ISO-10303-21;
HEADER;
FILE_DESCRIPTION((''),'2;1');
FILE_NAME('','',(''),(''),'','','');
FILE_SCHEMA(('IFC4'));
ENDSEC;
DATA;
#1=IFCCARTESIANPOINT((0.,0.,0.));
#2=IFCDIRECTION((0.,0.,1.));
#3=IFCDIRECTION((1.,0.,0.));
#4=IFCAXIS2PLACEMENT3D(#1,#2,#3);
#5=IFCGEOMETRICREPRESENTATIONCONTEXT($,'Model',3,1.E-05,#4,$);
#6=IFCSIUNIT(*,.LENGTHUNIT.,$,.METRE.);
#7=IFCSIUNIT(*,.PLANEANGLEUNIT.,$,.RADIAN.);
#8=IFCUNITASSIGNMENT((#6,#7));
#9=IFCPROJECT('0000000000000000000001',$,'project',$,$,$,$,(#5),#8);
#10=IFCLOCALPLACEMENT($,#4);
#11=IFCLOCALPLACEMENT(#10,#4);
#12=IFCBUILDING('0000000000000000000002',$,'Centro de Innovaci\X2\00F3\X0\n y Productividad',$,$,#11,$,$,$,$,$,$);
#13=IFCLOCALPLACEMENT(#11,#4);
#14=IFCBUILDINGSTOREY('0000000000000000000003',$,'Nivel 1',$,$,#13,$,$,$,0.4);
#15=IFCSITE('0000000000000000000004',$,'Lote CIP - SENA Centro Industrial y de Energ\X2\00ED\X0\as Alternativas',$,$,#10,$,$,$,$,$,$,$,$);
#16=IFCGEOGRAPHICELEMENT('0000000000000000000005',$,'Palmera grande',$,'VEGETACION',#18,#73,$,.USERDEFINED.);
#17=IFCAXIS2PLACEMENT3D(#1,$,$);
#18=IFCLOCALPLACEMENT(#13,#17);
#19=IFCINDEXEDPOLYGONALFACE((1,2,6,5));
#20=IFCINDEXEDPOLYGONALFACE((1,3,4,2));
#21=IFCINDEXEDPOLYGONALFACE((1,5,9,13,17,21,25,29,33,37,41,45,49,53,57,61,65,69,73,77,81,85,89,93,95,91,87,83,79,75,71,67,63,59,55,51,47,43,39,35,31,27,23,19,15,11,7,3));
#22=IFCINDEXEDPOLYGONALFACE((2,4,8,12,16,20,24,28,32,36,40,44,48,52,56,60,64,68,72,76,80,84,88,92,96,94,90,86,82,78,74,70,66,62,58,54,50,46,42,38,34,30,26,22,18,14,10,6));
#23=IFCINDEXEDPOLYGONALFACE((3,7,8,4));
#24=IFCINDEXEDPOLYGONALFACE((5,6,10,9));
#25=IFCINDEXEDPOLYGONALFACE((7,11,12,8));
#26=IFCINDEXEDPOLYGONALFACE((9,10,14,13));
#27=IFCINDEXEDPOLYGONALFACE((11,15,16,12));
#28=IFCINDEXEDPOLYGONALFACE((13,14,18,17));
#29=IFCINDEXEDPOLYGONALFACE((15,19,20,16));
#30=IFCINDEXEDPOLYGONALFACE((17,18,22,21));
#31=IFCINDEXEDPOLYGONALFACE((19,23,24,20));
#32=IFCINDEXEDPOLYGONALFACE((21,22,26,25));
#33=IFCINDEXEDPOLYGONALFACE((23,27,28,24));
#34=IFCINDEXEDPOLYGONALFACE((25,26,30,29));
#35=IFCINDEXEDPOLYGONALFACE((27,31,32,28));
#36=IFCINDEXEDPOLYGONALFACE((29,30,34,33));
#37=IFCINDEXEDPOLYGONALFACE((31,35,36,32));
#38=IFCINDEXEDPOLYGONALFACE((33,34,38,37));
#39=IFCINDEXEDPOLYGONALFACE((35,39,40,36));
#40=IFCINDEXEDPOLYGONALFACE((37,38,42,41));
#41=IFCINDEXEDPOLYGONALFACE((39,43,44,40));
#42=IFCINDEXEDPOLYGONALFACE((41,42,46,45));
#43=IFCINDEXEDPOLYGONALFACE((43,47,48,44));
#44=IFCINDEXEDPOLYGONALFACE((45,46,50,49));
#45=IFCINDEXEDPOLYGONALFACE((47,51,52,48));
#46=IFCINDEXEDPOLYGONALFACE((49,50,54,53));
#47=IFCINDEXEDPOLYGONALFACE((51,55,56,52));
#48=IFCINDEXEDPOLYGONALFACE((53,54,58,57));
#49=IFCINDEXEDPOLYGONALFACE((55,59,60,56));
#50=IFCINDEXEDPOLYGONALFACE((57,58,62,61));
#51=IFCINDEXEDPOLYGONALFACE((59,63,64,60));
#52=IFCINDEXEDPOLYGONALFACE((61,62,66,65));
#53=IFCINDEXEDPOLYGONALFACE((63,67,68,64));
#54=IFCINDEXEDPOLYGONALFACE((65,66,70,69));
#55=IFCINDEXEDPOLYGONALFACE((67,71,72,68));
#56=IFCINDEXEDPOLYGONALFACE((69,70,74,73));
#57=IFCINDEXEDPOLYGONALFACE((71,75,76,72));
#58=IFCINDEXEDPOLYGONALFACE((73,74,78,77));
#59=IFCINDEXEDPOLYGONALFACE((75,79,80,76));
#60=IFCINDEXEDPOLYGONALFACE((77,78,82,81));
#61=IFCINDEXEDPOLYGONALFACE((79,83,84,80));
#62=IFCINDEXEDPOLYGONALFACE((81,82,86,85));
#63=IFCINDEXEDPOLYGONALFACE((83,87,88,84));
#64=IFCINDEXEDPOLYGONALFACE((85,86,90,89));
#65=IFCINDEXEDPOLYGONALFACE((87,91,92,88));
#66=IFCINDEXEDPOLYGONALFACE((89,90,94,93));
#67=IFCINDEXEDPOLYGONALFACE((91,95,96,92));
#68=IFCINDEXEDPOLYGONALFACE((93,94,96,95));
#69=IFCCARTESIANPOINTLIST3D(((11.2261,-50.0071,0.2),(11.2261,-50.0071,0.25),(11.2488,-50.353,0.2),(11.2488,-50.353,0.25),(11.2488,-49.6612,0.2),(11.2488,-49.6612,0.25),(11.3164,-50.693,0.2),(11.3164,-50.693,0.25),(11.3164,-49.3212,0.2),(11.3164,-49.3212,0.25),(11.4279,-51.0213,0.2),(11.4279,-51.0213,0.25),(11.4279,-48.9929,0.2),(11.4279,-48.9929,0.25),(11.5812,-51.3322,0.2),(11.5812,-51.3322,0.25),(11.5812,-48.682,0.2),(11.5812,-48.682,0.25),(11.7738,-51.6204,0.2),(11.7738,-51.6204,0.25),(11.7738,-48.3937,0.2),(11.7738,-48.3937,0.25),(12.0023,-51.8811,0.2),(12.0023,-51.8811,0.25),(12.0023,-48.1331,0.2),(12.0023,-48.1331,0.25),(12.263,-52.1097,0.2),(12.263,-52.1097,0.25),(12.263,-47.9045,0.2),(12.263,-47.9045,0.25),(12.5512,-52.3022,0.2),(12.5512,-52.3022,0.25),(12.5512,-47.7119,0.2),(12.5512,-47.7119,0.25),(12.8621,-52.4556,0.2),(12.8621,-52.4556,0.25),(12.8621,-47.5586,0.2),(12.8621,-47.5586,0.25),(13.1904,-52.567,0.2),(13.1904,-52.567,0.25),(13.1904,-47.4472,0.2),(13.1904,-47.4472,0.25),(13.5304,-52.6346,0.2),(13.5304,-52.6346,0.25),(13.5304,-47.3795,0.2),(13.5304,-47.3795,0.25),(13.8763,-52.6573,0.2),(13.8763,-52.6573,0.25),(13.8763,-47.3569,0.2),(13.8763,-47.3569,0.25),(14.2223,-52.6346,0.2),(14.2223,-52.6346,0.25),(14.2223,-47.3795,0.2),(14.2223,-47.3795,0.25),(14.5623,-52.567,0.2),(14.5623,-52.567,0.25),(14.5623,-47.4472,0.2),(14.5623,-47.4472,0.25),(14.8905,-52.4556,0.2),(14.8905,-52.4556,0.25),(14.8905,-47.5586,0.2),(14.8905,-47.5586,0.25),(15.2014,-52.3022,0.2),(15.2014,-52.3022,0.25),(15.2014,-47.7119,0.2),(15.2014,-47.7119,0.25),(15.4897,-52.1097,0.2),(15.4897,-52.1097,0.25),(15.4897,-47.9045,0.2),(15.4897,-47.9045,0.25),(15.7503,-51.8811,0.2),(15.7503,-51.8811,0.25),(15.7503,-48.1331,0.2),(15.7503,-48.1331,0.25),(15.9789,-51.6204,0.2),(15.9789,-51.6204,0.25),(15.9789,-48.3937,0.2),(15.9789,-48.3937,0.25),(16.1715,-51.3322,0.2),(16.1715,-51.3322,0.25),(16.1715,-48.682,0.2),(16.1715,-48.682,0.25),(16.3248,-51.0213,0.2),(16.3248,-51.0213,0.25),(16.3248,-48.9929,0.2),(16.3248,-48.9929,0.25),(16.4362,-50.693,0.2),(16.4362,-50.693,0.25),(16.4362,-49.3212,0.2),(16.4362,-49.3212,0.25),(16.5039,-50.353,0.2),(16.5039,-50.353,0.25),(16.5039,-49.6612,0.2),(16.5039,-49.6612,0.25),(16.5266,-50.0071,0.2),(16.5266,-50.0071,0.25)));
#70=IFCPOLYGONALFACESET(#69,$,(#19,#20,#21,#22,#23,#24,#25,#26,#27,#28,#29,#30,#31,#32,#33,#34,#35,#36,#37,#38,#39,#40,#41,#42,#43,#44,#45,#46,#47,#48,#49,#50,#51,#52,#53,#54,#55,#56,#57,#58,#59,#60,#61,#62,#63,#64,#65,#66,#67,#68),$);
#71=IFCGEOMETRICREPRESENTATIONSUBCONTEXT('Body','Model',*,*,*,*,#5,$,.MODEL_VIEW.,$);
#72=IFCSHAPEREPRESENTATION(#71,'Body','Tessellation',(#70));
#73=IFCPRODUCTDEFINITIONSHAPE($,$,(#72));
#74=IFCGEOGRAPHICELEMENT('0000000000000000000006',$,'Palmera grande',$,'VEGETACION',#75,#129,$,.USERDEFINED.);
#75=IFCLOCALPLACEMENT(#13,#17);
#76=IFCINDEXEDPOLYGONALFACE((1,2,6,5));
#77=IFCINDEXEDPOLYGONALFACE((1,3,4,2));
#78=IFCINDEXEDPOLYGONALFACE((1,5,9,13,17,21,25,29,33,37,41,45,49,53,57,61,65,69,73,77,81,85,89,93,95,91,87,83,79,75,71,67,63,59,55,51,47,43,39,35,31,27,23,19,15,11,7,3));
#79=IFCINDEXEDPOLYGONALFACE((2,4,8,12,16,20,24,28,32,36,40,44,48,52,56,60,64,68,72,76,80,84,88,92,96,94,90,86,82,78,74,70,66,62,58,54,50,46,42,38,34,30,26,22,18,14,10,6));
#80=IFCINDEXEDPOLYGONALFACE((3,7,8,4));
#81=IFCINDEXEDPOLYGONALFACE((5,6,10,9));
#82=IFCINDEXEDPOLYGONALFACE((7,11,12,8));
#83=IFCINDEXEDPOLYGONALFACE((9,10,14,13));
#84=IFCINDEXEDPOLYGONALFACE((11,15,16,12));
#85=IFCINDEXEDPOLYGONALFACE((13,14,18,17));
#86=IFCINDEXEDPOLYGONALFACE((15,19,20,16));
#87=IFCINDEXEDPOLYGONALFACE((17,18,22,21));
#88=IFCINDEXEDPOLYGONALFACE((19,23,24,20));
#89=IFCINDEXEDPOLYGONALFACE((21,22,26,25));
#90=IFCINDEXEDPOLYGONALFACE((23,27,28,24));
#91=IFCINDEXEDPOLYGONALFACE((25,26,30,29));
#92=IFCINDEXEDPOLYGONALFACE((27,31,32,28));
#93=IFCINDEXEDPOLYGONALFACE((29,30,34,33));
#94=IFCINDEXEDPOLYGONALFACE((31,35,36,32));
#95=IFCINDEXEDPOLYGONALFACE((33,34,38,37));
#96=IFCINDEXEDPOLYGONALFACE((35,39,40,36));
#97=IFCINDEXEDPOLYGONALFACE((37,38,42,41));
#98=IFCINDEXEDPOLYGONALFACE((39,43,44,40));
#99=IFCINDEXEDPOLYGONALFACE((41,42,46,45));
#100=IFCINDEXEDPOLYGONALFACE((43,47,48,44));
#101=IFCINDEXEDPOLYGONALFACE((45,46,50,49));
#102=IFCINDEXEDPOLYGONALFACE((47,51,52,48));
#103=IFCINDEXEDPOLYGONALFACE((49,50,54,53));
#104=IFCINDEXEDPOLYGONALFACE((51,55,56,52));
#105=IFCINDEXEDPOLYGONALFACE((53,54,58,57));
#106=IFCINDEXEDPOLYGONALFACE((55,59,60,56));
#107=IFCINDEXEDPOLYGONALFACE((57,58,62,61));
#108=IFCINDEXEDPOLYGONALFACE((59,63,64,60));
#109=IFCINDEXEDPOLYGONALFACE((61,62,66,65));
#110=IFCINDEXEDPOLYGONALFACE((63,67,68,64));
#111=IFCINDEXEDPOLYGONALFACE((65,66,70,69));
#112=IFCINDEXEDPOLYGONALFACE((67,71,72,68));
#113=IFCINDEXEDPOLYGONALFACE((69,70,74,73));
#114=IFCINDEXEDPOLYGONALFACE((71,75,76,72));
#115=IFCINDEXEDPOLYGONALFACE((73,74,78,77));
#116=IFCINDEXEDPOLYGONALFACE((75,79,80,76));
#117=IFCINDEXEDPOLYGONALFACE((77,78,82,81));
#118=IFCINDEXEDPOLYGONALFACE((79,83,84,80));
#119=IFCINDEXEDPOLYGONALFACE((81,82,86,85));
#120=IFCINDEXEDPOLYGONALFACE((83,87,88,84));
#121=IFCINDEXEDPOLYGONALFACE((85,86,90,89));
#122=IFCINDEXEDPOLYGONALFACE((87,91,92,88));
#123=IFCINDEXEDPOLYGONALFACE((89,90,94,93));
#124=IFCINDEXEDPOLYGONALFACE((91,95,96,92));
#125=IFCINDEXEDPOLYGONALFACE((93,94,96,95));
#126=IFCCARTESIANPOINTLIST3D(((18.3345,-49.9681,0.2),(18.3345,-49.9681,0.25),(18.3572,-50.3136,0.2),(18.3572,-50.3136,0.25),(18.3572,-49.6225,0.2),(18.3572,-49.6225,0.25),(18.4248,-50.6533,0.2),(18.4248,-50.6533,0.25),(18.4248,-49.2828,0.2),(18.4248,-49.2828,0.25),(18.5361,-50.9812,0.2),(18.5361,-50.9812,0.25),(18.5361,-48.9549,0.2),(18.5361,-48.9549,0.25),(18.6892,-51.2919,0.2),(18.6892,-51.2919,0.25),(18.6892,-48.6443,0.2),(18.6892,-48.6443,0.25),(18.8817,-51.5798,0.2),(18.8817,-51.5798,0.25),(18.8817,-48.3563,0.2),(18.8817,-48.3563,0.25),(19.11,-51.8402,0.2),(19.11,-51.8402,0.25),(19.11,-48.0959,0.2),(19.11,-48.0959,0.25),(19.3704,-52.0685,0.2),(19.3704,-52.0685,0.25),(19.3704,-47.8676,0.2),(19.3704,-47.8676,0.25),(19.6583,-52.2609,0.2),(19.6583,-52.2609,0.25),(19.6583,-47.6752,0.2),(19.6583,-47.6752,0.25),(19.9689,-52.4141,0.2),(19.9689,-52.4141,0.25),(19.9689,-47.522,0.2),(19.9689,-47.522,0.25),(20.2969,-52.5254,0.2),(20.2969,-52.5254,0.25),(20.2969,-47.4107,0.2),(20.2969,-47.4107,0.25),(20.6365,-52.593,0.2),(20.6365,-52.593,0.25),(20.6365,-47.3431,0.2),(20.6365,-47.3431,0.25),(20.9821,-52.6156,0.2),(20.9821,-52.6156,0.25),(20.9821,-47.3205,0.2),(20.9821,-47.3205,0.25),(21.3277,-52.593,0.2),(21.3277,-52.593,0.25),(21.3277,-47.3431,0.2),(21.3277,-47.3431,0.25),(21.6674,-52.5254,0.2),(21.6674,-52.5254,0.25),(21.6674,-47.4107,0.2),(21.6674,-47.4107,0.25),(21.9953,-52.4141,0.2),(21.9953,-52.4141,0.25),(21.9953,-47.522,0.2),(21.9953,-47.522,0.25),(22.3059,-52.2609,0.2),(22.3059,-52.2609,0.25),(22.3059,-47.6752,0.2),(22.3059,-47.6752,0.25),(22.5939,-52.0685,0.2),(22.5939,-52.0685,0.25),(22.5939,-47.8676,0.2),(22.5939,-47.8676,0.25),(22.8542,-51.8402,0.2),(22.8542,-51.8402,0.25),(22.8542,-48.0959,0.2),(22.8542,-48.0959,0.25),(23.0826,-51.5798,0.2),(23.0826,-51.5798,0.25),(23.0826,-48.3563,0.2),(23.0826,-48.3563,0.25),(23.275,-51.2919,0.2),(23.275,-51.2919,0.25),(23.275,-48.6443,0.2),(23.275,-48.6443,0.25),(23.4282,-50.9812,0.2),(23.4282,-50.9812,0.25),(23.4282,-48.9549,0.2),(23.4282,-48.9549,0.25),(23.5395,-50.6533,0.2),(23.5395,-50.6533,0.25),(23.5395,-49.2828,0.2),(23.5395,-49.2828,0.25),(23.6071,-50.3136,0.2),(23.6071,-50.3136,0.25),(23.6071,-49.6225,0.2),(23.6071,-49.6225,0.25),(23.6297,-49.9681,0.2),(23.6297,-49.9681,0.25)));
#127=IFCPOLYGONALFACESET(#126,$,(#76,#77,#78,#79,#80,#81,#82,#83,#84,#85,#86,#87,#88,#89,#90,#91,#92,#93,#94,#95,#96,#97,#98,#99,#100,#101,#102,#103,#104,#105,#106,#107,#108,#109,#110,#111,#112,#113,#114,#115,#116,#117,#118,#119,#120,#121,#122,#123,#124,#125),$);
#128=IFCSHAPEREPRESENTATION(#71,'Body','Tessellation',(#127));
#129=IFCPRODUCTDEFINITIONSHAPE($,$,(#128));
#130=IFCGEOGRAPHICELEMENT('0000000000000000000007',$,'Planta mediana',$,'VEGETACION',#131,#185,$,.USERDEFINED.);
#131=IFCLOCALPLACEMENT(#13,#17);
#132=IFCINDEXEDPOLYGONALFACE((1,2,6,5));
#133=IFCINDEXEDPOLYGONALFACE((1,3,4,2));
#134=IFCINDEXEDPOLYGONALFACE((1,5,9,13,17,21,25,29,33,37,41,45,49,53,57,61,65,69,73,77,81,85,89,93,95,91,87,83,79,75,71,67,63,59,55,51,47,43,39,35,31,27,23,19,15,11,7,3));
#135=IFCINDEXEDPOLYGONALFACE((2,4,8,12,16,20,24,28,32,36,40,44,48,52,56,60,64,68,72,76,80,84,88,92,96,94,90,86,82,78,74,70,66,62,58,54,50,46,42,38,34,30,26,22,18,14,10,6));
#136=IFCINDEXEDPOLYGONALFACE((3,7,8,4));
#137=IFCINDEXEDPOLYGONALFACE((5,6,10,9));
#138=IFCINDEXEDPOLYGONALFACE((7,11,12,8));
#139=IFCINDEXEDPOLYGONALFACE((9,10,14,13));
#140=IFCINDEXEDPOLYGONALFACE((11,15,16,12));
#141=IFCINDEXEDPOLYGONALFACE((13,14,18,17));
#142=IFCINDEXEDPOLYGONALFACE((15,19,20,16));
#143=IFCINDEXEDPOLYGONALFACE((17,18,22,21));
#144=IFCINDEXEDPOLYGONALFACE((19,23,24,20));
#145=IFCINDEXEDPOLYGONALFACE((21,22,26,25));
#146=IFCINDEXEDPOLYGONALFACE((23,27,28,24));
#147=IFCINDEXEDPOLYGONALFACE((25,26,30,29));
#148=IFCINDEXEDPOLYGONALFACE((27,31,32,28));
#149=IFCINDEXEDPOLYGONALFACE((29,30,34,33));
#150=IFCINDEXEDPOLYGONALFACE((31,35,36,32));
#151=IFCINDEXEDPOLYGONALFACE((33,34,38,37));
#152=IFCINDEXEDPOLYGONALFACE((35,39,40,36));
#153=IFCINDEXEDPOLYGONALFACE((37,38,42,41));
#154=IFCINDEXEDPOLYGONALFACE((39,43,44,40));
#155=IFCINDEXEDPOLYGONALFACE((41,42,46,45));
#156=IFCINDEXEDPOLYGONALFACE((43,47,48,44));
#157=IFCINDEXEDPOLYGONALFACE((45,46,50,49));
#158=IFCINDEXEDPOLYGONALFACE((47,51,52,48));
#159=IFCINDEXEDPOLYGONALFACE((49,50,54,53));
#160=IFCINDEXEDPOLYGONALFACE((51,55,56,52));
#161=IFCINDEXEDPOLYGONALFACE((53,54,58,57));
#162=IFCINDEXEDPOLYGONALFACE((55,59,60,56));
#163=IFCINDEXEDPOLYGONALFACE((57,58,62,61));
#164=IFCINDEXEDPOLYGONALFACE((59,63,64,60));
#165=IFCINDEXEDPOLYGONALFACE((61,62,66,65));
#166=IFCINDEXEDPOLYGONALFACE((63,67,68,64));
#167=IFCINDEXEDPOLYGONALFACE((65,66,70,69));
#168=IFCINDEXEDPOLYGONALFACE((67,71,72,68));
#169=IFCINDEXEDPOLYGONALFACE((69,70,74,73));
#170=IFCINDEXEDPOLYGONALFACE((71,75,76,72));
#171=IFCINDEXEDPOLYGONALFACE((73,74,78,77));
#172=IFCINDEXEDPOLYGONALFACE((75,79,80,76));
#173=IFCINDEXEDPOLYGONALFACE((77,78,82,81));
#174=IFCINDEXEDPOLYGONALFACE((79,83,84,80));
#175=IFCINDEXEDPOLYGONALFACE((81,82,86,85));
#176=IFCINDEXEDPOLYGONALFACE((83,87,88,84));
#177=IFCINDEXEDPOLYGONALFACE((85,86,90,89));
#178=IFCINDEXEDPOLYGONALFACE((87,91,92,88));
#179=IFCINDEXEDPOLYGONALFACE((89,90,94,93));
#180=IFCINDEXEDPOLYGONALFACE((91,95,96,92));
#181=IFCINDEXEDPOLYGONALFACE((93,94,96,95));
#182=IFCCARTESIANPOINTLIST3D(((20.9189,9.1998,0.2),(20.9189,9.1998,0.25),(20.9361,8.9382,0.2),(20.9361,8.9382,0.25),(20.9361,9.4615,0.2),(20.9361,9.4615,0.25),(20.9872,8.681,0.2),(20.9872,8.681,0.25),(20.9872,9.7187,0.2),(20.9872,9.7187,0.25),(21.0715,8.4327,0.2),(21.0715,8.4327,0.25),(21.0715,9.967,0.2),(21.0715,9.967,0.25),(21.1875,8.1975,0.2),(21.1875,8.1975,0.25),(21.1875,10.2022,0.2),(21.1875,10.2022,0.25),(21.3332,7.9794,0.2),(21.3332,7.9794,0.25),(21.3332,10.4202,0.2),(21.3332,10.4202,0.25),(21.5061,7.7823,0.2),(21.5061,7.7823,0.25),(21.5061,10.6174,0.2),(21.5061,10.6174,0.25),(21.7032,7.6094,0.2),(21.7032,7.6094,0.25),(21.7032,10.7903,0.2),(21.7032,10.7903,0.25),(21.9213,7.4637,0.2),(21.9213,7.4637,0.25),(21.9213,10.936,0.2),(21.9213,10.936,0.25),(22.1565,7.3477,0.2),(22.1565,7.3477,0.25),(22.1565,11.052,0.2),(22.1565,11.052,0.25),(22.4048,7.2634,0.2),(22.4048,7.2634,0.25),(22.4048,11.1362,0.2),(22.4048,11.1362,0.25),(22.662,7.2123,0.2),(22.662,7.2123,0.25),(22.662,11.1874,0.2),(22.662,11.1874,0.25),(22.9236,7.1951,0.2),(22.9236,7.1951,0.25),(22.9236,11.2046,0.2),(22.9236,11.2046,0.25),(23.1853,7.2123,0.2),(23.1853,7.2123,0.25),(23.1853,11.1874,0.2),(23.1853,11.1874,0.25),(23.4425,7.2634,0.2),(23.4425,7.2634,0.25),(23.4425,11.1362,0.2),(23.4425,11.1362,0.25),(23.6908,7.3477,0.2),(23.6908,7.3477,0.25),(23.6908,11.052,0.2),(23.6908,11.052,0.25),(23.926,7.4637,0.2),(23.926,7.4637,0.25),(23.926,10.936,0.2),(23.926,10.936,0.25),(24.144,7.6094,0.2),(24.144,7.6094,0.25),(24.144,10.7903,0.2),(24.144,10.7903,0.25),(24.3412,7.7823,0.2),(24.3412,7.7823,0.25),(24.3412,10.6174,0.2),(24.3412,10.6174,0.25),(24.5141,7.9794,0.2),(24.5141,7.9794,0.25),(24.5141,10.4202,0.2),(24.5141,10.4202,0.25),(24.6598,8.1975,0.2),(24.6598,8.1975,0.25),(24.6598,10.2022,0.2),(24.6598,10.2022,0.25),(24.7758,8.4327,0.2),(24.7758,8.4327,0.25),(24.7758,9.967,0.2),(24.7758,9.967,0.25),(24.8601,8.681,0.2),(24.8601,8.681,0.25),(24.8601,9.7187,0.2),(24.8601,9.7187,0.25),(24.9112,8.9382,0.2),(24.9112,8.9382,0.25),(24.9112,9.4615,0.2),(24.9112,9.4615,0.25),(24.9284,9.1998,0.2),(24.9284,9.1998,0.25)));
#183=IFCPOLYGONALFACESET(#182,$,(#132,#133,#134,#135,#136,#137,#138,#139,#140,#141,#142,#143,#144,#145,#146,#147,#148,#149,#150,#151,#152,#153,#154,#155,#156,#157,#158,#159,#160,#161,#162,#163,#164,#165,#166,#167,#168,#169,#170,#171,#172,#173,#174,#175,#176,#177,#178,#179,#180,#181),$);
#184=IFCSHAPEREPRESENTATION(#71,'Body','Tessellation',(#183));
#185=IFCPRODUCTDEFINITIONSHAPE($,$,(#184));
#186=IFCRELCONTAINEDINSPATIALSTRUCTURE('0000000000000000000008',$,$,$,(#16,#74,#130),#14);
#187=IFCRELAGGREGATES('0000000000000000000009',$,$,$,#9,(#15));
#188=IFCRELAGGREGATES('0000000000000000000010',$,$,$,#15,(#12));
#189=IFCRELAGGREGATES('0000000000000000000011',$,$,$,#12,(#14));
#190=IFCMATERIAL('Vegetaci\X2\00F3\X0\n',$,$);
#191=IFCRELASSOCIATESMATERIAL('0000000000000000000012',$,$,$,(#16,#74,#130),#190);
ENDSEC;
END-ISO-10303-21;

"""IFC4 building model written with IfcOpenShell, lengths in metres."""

from ifc_helpers import new_model, si_unit, frame, origin_with_axes, place, context, subcontext, project, spatial, polyline, outline, extrude, material, element, save


model = new_model("IFC4")

# Units and contexts
model_context = context("Model", 3, precision=1e-05, world=origin_with_axes())
body_context = subcontext(model_context, "Body", "Model", "MODEL_VIEW")
ifc_project = project(units=[si_unit("LENGTHUNIT", "METRE"), si_unit("PLANEANGLEUNIT", "RADIAN")], contexts=[model_context])

# Site, building, storey
site_placement = place(None, origin_with_axes())
site = spatial("IfcSite", under=ifc_project, at=site_placement, Name="Lote CIP - SENA Centro Industrial y de Energías Alternativas")
building_placement = place(site_placement, origin_with_axes())
building = spatial("IfcBuilding", under=site, at=building_placement, Name="Centro de Innovación y Productividad")
storey_placement = place(building_placement, origin_with_axes())
storey = spatial("IfcBuildingStorey", under=building, at=storey_placement, Name="Nivel 1", Elevation=0.4)

# Geographic elements
ifc_material_1 = material(Name="Vegetación")
geographic_element_1_placement = place(storey_placement, origin_with_axes())
element("IfcGeographicElement", 1, at=geographic_element_1_placement, inside=storey, material=ifc_material_1, Name="Palmera grande", ObjectType="VEGETACION", PredefinedType="USERDEFINED", context=body_context, shape_type="SweptSolid", body=[
    extrude(outline(polyline([(16.5266, -50.0071), (16.5039, -50.353), (16.4362, -50.693), (16.3248, -51.0213), (16.1715, -51.3322), (15.9789, -51.6204), (15.7503, -51.8811), (15.4897, -52.1097), (15.2014, -52.3022), (14.8905, -52.4556), (14.5623, -52.567), (14.2223, -52.6346), (13.8763, -52.6573), (13.5304, -52.6346), (13.1904, -52.567), (12.8621, -52.4556), (12.5512, -52.3022), (12.263, -52.1097), (12.0023, -51.8811), (11.7738, -51.6204), (11.5812, -51.3322), (11.4279, -51.0213), (11.3164, -50.693), (11.2488, -50.353), (11.2261, -50.0071), (11.2488, -49.6612), (11.3164, -49.3212), (11.4279, -48.9929), (11.5812, -48.682), (11.7738, -48.3937), (12.0023, -48.1331), (12.263, -47.9045), (12.5512, -47.7119), (12.8621, -47.5586), (13.1904, -47.4472), (13.5304, -47.3795), (13.8763, -47.3569), (14.2223, -47.3795), (14.5623, -47.4472), (14.8905, -47.5586), (15.2014, -47.7119), (15.4897, -47.9045), (15.7503, -48.1331), (15.9789, -48.3937), (16.1715, -48.682), (16.3248, -48.9929), (16.4362, -49.3212), (16.5039, -49.6612), (16.5266, -50.0071)])), frame((0.0, 0.0, 0.2)), (0.0, 0.0, 1.0), 0.05),
])
geographic_element_2_placement = place(storey_placement, origin_with_axes())
element("IfcGeographicElement", 2, at=geographic_element_2_placement, inside=storey, material=ifc_material_1, Name="Palmera grande", ObjectType="VEGETACION", PredefinedType="USERDEFINED", context=body_context, shape_type="SweptSolid", body=[
    extrude(outline(polyline([(23.6297, -49.9681), (23.6071, -50.3136), (23.5395, -50.6533), (23.4282, -50.9812), (23.275, -51.2919), (23.0826, -51.5798), (22.8542, -51.8402), (22.5939, -52.0685), (22.3059, -52.2609), (21.9953, -52.4141), (21.6674, -52.5254), (21.3277, -52.593), (20.9821, -52.6156), (20.6365, -52.593), (20.2969, -52.5254), (19.9689, -52.4141), (19.6583, -52.2609), (19.3704, -52.0685), (19.11, -51.8402), (18.8817, -51.5798), (18.6892, -51.2919), (18.5361, -50.9812), (18.4248, -50.6533), (18.3572, -50.3136), (18.3345, -49.9681), (18.3572, -49.6225), (18.4248, -49.2828), (18.5361, -48.9549), (18.6892, -48.6443), (18.8817, -48.3563), (19.11, -48.0959), (19.3704, -47.8676), (19.6583, -47.6752), (19.9689, -47.522), (20.2969, -47.4107), (20.6365, -47.3431), (20.9821, -47.3205), (21.3277, -47.3431), (21.6674, -47.4107), (21.9953, -47.522), (22.3059, -47.6752), (22.5939, -47.8676), (22.8542, -48.0959), (23.0826, -48.3563), (23.275, -48.6443), (23.4282, -48.9549), (23.5395, -49.2828), (23.6071, -49.6225), (23.6297, -49.9681)])), frame((0.0, 0.0, 0.2)), (0.0, 0.0, 1.0), 0.05),
])
geographic_element_3_placement = place(storey_placement, origin_with_axes())
element("IfcGeographicElement", 3, at=geographic_element_3_placement, inside=storey, material=ifc_material_1, Name="Planta mediana", ObjectType="VEGETACION", PredefinedType="USERDEFINED", context=body_context, shape_type="SweptSolid", body=[
    extrude(outline(polyline([(24.9284, 9.1998), (24.9112, 8.9382), (24.8601, 8.681), (24.7758, 8.4327), (24.6598, 8.1975), (24.5141, 7.9794), (24.3412, 7.7823), (24.144, 7.6094), (23.926, 7.4637), (23.6908, 7.3477), (23.4425, 7.2634), (23.1853, 7.2123), (22.9236, 7.1951), (22.662, 7.2123), (22.4048, 7.2634), (22.1565, 7.3477), (21.9213, 7.4637), (21.7032, 7.6094), (21.5061, 7.7823), (21.3332, 7.9794), (21.1875, 8.1975), (21.0715, 8.4327), (20.9872, 8.681), (20.9361, 8.9382), (20.9189, 9.1998), (20.9361, 9.4615), (20.9872, 9.7187), (21.0715, 9.967), (21.1875, 10.2022), (21.3332, 10.4202), (21.5061, 10.6174), (21.7032, 10.7903), (21.9213, 10.936), (22.1565, 11.052), (22.4048, 11.1362), (22.662, 11.1874), (22.9236, 11.2046), (23.1853, 11.1874), (23.4425, 11.1362), (23.6908, 11.052), (23.926, 10.936), (24.144, 10.7903), (24.3412, 10.6174), (24.5141, 10.4202), (24.6598, 10.2022), (24.7758, 9.967), (24.8601, 9.7187), (24.9112, 9.4615), (24.9284, 9.1998)])), frame((0.0, 0.0, 0.2)), (0.0, 0.0, 1.0), 0.05),
])

save(model, "model.ifc")
